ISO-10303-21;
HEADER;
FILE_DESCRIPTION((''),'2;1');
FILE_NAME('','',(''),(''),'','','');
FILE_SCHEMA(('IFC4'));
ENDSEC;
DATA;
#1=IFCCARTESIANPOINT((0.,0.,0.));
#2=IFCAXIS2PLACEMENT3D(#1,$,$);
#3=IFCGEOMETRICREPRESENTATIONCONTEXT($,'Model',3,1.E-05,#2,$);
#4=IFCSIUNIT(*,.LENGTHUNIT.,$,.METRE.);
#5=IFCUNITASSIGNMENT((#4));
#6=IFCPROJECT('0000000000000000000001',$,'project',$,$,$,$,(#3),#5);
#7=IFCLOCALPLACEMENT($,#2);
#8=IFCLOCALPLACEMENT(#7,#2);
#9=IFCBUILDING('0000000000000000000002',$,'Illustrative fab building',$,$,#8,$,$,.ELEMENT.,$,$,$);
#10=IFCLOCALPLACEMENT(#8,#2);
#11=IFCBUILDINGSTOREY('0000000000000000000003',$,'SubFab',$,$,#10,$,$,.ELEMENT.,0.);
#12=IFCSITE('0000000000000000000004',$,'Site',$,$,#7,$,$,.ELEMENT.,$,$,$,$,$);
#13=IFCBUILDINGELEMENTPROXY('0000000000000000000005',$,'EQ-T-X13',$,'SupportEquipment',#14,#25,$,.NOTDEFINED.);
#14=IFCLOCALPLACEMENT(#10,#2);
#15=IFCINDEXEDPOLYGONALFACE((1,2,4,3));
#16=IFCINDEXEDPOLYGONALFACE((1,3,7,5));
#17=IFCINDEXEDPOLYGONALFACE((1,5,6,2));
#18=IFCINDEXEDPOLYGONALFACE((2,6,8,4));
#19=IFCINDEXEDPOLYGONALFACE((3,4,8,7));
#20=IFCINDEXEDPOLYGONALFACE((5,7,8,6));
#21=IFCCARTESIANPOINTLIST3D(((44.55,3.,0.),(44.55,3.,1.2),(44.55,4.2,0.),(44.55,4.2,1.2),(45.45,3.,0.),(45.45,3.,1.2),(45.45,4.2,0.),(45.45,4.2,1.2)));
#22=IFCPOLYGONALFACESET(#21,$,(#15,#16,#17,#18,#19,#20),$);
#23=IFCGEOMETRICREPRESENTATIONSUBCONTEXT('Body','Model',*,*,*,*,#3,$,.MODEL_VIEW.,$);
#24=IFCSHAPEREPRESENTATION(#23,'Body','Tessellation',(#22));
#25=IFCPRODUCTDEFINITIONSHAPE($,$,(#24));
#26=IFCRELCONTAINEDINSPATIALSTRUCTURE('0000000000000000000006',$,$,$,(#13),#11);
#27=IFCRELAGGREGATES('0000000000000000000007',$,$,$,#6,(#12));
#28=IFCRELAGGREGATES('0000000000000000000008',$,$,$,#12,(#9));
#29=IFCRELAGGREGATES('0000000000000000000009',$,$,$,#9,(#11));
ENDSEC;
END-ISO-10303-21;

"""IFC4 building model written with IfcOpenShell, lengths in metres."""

from ifc_helpers import new_model, si_unit, frame, origin, origin_2d, place, context, subcontext, project, spatial, rectangle, extrude, element, save


model = new_model("IFC4")

# Units and contexts
model_context = context("Model", 3, precision=1e-05, world=origin())
body_context = subcontext(model_context, "Body", "Model", "MODEL_VIEW")
ifc_project = project(units=[si_unit("LENGTHUNIT", "METRE")], contexts=[model_context])

# Site, building, storey
site_placement = place(None, origin())
site = spatial("IfcSite", under=ifc_project, at=site_placement, Name="Site", CompositionType="ELEMENT")
building_placement = place(site_placement, origin())
building = spatial("IfcBuilding", under=site, at=building_placement, Name="Illustrative fab building", CompositionType="ELEMENT")
storey_placement = place(building_placement, origin())
storey = spatial("IfcBuildingStorey", under=building, at=storey_placement, Name="SubFab", CompositionType="ELEMENT", Elevation=0.0)

# Building element proxy
proxy_1_placement = place(storey_placement, frame((45.0, 3.6, 0.0)))
element("IfcBuildingElementProxy", 1, at=proxy_1_placement, inside=storey, Name="EQ-T-X13", ObjectType="SupportEquipment", PredefinedType="NOTDEFINED", context=body_context, shape_type="SweptSolid", body=[
    extrude(rectangle(XDim=0.9, YDim=1.2, at=origin_2d()), origin(), (0.0, 0.0, 1.0), 1.2),
])

save(model, "model.ifc")
